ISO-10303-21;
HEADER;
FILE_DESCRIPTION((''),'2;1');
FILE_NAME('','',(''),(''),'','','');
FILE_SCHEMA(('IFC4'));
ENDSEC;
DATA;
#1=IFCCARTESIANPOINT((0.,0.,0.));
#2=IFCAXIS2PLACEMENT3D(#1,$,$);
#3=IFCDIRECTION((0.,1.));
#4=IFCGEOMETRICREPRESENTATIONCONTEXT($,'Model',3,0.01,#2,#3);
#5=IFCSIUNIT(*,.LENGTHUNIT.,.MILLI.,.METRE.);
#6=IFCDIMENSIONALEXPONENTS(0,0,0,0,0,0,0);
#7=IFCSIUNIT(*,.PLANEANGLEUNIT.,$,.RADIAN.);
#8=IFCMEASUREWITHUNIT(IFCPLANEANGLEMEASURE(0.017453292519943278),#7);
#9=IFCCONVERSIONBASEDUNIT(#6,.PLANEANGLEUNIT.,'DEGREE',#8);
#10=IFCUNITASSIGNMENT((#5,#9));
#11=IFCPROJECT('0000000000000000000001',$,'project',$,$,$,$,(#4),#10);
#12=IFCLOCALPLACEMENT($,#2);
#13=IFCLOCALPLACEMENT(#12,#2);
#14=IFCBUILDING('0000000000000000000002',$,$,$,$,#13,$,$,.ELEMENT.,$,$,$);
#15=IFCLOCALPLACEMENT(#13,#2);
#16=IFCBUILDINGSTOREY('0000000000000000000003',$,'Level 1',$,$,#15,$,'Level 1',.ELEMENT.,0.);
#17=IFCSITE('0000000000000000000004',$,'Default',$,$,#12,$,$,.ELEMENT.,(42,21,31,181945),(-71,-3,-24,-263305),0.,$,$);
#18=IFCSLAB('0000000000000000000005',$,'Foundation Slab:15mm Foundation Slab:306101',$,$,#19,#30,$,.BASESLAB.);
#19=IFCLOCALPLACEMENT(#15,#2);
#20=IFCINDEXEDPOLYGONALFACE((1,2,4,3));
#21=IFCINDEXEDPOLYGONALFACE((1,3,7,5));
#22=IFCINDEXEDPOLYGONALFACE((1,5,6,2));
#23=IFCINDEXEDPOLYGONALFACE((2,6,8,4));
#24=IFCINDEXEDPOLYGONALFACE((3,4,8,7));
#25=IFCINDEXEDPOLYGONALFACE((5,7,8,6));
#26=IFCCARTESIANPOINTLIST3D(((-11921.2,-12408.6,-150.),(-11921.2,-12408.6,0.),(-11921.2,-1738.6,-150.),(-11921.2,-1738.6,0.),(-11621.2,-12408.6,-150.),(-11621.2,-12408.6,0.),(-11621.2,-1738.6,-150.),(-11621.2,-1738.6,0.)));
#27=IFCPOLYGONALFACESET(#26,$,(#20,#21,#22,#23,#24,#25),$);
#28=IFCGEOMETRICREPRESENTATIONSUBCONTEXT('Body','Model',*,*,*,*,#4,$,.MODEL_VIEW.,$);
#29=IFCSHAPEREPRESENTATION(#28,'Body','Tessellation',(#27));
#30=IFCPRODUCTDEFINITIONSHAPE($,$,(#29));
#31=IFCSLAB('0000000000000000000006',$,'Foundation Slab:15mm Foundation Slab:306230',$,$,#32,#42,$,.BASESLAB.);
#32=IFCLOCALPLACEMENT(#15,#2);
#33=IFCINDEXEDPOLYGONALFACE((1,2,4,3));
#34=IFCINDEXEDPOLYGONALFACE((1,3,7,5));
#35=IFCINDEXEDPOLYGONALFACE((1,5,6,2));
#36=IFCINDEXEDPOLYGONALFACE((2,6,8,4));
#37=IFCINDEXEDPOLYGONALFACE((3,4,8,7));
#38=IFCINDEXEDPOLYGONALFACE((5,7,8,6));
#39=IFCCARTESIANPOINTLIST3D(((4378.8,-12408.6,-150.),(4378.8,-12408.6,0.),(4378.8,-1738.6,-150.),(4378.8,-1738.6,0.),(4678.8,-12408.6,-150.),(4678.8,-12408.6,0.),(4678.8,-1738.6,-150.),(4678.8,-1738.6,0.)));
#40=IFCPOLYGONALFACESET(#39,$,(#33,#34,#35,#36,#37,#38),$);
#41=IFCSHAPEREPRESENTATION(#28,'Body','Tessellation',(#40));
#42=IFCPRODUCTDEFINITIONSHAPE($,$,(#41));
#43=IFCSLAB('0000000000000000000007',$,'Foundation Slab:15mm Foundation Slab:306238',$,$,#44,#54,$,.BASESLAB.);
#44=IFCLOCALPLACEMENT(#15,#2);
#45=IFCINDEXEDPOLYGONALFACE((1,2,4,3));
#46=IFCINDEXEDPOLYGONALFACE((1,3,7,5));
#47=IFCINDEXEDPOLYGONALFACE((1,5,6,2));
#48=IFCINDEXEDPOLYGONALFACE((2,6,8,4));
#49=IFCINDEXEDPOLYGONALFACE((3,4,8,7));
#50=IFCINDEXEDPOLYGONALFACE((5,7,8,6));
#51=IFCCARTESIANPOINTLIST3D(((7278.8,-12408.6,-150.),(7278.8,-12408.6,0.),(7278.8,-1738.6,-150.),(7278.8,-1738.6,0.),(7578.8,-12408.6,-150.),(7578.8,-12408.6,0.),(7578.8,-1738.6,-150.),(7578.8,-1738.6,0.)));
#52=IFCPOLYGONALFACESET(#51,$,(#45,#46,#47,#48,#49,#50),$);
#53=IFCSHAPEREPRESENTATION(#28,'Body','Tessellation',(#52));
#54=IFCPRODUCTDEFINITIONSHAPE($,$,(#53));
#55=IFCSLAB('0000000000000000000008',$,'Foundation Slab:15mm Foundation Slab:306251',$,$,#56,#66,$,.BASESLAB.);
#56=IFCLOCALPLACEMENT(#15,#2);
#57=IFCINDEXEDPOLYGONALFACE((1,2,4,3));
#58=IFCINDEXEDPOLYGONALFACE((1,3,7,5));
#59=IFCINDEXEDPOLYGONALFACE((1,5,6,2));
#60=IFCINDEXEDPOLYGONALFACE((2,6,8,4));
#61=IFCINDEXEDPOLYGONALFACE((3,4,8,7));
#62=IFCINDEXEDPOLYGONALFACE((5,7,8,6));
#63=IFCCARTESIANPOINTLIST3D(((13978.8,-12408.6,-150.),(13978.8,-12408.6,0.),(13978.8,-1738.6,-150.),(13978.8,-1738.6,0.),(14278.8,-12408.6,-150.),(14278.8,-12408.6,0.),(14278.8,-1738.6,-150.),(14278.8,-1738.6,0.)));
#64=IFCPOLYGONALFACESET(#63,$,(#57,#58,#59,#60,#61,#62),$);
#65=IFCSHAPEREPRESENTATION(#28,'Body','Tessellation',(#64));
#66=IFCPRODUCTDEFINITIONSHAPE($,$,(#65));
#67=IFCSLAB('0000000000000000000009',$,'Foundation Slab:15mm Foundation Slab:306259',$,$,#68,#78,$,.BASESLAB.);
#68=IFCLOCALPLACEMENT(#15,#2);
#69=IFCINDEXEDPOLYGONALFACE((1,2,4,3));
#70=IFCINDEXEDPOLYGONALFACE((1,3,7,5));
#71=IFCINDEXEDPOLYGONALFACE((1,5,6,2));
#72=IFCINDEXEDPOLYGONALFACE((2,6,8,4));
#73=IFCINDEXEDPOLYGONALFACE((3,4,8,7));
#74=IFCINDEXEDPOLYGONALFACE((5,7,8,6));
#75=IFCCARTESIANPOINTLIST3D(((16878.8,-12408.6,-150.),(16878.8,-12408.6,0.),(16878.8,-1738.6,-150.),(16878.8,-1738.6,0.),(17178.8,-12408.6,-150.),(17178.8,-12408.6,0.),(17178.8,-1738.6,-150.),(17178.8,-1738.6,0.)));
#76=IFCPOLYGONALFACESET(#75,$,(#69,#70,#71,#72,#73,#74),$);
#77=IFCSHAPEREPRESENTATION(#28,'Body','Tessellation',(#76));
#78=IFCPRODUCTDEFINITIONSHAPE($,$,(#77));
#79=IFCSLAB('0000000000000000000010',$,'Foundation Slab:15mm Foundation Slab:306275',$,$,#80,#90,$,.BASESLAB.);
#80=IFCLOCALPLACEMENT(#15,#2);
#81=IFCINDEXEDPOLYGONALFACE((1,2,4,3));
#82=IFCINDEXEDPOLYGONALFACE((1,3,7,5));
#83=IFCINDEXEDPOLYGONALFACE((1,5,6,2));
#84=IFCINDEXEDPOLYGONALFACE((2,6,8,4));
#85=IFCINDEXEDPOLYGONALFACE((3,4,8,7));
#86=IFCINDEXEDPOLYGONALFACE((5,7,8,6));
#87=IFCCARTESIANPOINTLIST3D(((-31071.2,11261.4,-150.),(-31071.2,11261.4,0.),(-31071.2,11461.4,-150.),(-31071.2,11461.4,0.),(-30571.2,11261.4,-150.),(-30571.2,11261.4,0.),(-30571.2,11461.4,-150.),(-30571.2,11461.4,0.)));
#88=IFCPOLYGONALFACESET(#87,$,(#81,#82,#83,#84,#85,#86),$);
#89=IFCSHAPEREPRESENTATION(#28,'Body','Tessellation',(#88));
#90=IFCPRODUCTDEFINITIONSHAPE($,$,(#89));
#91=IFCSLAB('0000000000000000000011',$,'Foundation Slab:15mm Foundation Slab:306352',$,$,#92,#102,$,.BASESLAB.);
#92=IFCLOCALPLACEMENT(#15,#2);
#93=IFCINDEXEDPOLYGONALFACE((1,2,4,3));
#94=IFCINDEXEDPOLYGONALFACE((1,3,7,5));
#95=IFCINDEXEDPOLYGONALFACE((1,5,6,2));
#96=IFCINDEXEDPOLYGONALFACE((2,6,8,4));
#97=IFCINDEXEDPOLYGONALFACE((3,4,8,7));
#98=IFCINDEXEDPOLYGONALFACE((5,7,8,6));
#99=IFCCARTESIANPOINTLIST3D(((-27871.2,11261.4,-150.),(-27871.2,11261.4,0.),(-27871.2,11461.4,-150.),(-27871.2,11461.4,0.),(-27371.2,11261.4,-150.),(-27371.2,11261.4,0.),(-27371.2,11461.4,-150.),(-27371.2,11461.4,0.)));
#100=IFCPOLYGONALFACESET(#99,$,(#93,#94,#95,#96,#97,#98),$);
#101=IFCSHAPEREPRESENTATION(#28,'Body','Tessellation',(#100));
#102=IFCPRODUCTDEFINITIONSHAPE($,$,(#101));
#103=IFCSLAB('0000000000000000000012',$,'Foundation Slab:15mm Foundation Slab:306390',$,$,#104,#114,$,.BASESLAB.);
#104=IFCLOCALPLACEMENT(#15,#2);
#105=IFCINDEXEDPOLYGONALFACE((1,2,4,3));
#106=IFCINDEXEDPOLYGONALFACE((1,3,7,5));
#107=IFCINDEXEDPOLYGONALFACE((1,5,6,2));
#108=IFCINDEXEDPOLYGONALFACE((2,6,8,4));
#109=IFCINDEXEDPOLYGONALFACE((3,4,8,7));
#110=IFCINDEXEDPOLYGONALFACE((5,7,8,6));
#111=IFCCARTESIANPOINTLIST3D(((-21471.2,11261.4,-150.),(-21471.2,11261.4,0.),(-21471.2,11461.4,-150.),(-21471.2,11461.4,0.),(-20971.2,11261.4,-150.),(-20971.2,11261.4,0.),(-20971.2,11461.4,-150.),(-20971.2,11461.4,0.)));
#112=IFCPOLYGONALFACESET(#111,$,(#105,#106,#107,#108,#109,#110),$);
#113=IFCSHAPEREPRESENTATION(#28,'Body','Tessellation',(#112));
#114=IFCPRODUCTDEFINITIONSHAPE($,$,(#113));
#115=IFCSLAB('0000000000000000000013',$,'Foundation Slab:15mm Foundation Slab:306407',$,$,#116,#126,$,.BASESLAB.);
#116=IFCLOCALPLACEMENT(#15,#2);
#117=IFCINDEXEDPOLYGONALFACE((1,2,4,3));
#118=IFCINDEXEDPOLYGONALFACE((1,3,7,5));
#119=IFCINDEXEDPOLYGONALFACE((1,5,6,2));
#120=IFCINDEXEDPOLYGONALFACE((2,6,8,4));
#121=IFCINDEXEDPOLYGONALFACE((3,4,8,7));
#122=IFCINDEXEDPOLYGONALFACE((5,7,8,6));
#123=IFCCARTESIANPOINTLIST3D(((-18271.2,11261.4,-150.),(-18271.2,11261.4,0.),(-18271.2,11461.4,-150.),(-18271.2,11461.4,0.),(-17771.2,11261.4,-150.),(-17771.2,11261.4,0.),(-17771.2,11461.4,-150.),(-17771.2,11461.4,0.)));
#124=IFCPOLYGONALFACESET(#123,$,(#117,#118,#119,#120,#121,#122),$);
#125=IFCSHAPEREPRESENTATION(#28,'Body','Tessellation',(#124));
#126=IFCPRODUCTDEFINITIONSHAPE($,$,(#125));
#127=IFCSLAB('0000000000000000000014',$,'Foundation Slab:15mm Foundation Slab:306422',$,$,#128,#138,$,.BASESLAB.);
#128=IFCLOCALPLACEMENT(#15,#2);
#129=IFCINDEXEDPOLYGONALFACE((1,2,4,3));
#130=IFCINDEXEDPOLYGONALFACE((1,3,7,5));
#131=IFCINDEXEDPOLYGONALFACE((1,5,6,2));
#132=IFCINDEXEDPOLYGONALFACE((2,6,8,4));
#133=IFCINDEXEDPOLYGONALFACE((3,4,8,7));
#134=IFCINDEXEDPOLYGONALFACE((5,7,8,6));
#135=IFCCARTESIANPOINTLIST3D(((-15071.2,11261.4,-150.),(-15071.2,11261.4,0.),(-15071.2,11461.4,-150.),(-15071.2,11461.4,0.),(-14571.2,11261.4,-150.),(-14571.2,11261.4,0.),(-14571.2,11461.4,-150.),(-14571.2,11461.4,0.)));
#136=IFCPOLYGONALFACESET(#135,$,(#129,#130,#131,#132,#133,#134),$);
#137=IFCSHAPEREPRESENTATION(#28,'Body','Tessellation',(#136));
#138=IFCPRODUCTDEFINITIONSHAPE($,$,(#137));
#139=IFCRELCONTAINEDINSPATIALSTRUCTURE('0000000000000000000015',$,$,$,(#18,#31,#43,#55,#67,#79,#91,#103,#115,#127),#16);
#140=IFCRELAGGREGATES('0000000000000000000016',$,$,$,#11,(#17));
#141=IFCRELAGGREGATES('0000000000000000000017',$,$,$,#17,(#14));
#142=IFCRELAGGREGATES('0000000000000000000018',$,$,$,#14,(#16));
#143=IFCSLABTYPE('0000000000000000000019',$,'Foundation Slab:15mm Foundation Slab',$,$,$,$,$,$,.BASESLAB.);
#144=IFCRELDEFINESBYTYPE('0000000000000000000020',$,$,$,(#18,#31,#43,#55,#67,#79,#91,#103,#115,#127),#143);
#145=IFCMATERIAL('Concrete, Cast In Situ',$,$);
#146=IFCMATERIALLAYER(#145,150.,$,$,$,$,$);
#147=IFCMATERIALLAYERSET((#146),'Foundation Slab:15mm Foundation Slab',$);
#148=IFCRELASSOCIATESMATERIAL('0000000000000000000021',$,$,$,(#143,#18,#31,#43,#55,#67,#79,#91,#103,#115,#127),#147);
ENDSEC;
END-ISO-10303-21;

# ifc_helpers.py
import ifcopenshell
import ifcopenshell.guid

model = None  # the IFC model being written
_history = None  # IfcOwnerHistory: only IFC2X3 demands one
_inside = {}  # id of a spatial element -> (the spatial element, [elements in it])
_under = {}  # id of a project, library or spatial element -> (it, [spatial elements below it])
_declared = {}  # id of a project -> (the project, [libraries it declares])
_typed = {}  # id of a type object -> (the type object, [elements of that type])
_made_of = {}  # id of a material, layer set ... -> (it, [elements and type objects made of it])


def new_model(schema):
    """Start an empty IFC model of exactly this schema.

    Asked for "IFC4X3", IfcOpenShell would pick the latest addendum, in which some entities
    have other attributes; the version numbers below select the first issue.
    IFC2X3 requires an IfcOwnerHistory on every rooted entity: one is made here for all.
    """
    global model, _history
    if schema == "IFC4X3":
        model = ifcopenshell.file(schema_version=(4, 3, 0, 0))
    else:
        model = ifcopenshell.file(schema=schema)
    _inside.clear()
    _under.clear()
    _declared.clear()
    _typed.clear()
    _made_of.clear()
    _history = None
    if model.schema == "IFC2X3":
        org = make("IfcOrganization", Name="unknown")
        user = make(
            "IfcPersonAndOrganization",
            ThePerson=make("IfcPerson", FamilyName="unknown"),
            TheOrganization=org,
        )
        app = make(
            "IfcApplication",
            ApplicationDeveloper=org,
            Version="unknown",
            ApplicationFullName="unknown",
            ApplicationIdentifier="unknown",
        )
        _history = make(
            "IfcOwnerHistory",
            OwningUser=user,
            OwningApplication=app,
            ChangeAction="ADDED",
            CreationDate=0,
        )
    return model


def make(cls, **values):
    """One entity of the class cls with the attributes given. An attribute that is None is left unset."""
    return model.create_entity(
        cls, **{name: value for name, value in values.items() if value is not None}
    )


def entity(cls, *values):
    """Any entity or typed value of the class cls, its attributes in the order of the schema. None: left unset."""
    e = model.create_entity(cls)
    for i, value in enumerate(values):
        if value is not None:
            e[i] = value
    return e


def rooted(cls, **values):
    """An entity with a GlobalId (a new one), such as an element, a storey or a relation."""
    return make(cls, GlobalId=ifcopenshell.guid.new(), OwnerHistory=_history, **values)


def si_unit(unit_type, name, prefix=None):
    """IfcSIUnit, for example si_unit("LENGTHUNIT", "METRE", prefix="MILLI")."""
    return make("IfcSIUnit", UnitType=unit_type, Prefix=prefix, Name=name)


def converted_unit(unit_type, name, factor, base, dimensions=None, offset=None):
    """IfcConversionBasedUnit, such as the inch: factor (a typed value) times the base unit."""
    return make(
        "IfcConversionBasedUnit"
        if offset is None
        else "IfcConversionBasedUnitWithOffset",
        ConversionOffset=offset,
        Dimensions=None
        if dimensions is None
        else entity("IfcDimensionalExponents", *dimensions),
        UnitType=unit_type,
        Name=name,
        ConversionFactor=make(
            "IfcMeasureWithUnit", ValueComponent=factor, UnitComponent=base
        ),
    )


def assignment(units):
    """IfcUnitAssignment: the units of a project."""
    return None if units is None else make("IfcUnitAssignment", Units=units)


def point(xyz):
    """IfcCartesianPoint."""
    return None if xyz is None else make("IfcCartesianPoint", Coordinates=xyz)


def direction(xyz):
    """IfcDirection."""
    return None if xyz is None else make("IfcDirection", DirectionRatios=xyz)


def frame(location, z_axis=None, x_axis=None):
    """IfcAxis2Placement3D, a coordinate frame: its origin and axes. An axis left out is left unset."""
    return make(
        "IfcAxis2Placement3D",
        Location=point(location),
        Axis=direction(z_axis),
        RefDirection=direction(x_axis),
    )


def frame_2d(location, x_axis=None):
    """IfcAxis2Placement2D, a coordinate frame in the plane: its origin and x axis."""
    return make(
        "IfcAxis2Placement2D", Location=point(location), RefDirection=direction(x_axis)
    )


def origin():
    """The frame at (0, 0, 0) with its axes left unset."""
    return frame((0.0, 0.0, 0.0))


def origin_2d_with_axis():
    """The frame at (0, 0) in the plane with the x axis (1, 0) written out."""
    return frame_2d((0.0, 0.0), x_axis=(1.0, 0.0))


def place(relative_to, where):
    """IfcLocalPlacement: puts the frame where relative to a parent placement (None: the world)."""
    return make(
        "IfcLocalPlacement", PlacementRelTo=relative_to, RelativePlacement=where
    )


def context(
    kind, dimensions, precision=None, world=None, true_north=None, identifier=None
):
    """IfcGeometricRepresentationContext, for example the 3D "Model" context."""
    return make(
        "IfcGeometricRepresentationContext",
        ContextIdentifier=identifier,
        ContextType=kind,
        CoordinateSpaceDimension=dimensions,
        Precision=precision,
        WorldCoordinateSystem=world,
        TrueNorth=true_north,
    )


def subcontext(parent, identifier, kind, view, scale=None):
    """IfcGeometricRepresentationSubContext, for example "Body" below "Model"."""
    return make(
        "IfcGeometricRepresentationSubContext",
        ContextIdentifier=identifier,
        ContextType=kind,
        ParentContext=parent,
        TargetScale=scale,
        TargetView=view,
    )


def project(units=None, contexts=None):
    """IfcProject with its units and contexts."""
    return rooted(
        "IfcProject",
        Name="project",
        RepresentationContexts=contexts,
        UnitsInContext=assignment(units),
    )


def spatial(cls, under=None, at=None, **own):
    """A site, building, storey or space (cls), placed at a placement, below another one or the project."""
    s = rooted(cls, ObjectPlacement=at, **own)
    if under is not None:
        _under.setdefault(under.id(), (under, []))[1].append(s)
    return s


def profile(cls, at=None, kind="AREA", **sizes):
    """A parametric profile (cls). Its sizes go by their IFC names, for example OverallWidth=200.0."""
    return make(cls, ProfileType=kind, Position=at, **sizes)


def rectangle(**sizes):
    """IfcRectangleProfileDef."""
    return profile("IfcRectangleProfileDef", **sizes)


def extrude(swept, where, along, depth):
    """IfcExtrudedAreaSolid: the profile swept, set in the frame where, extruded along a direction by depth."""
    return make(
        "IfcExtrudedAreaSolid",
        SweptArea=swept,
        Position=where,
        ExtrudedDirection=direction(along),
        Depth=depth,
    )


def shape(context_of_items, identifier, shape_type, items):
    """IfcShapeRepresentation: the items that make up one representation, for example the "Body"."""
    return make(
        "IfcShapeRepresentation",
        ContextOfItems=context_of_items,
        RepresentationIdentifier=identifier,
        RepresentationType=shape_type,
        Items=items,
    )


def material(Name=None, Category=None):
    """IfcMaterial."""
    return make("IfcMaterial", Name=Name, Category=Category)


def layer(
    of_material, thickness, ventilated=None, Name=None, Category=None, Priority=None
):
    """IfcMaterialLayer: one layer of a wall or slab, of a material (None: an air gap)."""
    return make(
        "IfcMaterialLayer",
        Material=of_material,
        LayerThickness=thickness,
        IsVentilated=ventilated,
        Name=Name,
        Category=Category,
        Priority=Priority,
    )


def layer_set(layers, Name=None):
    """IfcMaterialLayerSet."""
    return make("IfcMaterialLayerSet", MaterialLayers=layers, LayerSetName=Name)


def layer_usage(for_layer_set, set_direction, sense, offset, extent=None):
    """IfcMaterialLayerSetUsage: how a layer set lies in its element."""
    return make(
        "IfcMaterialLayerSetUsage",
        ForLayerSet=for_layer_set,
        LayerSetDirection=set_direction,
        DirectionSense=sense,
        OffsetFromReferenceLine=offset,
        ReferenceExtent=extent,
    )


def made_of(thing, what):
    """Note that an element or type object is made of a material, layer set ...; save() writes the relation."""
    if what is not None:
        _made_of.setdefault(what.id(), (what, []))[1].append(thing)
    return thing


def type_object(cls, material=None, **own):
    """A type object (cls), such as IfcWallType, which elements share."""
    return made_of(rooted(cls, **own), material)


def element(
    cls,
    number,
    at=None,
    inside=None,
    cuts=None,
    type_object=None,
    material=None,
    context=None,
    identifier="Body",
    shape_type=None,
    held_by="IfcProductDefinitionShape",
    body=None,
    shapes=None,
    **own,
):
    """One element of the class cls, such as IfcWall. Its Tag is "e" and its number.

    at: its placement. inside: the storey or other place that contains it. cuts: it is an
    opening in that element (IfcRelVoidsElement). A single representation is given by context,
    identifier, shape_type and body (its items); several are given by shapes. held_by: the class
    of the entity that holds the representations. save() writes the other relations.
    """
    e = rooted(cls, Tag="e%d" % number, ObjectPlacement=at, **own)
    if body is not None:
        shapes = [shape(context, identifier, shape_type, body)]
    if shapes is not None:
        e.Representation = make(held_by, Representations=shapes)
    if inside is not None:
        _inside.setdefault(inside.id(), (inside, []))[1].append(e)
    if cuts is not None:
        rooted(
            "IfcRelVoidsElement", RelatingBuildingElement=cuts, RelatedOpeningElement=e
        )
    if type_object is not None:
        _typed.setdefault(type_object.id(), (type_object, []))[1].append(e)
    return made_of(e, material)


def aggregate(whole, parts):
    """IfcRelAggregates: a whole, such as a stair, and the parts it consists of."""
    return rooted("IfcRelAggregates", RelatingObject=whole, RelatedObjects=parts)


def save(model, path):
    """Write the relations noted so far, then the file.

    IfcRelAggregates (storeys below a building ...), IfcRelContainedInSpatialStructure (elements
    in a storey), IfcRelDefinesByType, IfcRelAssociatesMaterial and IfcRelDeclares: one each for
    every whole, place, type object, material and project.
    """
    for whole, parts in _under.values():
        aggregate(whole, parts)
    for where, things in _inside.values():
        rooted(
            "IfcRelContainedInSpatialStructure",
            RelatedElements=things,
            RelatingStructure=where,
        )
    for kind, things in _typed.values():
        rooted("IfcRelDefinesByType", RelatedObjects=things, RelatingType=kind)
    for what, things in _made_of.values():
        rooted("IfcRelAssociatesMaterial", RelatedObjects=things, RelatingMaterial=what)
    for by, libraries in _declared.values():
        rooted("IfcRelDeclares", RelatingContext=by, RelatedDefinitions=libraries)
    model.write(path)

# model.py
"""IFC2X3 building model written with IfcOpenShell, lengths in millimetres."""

from ifc_helpers import new_model, entity, si_unit, converted_unit, direction, frame, frame_2d, origin, origin_2d_with_axis, place, context, subcontext, project, spatial, rectangle, extrude, material, layer, layer_set, layer_usage, type_object, element, save


model = new_model("IFC2X3")

# Units and contexts
model_context = context("Model", 3, precision=0.01, world=origin(), true_north=direction((0.0, 1.0)))
body_context = subcontext(model_context, "Body", "Model", "MODEL_VIEW")
ifc_project = project(units=[si_unit("LENGTHUNIT", "METRE", prefix="MILLI"), converted_unit("PLANEANGLEUNIT", "DEGREE", entity("IfcPlaneAngleMeasure", 0.017453292519943278), si_unit("PLANEANGLEUNIT", "RADIAN"), dimensions=[0, 0, 0, 0, 0, 0, 0])], contexts=[model_context])

# Site, building, storey
site_placement = place(None, origin())
site = spatial("IfcSite", under=ifc_project, at=site_placement, Name="Default", CompositionType="ELEMENT", RefLatitude=(42, 21, 31, 181945), RefLongitude=(-71, -3, -24, -263305), RefElevation=0.0)
building_placement = place(site_placement, origin())
building = spatial("IfcBuilding", under=site, at=building_placement, CompositionType="ELEMENT")
storey_placement = place(building_placement, origin())
storey = spatial("IfcBuildingStorey", under=building, at=storey_placement, Name="Level 1", LongName="Level 1", CompositionType="ELEMENT", Elevation=0.0)

# Slabs
ifc_material = material(Name="Concrete, Cast In Situ")
ifc_layer = layer(ifc_material, 150.0)
ifc_layer_set = layer_set([ifc_layer], Name="Foundation Slab:15mm Foundation Slab")
slab_type = type_object("IfcSlabType", Name="Foundation Slab:15mm Foundation Slab", PredefinedType="BASESLAB", material=ifc_layer_set)
ifc_layer_usage_1 = layer_usage(ifc_layer_set, "AXIS3", "POSITIVE", 0.0)
slab_1_placement = place(storey_placement, origin())
element("IfcSlab", 1, at=slab_1_placement, inside=storey, type_object=slab_type, material=ifc_layer_usage_1, Name="Foundation Slab:15mm Foundation Slab:306101", PredefinedType="BASESLAB", context=body_context, shape_type="SweptSolid", body=[
    extrude(rectangle(XDim=10670.0, YDim=300.0, at=origin_2d_with_axis()), frame((-11771.2, -7073.6, 0.0), z_axis=(0.0, 0.0, -1.0), x_axis=(0.0, 1.0, 0.0)), (0.0, 0.0, 1.0), 150.0),
])
ifc_layer_usage_2 = layer_usage(ifc_layer_set, "AXIS3", "POSITIVE", 0.0)
slab_2_placement = place(storey_placement, origin())
element("IfcSlab", 2, at=slab_2_placement, inside=storey, type_object=slab_type, material=ifc_layer_usage_2, Name="Foundation Slab:15mm Foundation Slab:306230", PredefinedType="BASESLAB", context=body_context, shape_type="SweptSolid", body=[
    extrude(rectangle(XDim=10670.0, YDim=300.0, at=origin_2d_with_axis()), frame((4528.8, -7073.6, 0.0), z_axis=(0.0, 0.0, -1.0), x_axis=(0.0, 1.0, 0.0)), (0.0, 0.0, 1.0), 150.0),
])
ifc_layer_usage_3 = layer_usage(ifc_layer_set, "AXIS3", "POSITIVE", 0.0)
slab_3_placement = place(storey_placement, origin())
element("IfcSlab", 3, at=slab_3_placement, inside=storey, type_object=slab_type, material=ifc_layer_usage_3, Name="Foundation Slab:15mm Foundation Slab:306238", PredefinedType="BASESLAB", context=body_context, shape_type="SweptSolid", body=[
    extrude(rectangle(XDim=10670.0, YDim=300.0, at=origin_2d_with_axis()), frame((7428.8, -7073.6, 0.0), z_axis=(0.0, 0.0, -1.0), x_axis=(0.0, 1.0, 0.0)), (0.0, 0.0, 1.0), 150.0),
])
ifc_layer_usage_4 = layer_usage(ifc_layer_set, "AXIS3", "POSITIVE", 0.0)
slab_4_placement = place(storey_placement, origin())
element("IfcSlab", 4, at=slab_4_placement, inside=storey, type_object=slab_type, material=ifc_layer_usage_4, Name="Foundation Slab:15mm Foundation Slab:306251", PredefinedType="BASESLAB", context=body_context, shape_type="SweptSolid", body=[
    extrude(rectangle(XDim=10670.0, YDim=300.0, at=origin_2d_with_axis()), frame((14128.8, -7073.6, 0.0), z_axis=(0.0, 0.0, -1.0), x_axis=(0.0, 1.0, 0.0)), (0.0, 0.0, 1.0), 150.0),
])
ifc_layer_usage_5 = layer_usage(ifc_layer_set, "AXIS3", "POSITIVE", 0.0)
slab_5_placement = place(storey_placement, origin())
element("IfcSlab", 5, at=slab_5_placement, inside=storey, type_object=slab_type, material=ifc_layer_usage_5, Name="Foundation Slab:15mm Foundation Slab:306259", PredefinedType="BASESLAB", context=body_context, shape_type="SweptSolid", body=[
    extrude(rectangle(XDim=10670.0, YDim=300.0, at=origin_2d_with_axis()), frame((17028.8, -7073.6, 0.0), z_axis=(0.0, 0.0, -1.0), x_axis=(0.0, 1.0, 0.0)), (0.0, 0.0, 1.0), 150.0),
])
ifc_layer_usage_6 = layer_usage(ifc_layer_set, "AXIS3", "POSITIVE", 0.0)
slab_6_placement = place(storey_placement, origin())
element("IfcSlab", 6, at=slab_6_placement, inside=storey, type_object=slab_type, material=ifc_layer_usage_6, Name="Foundation Slab:15mm Foundation Slab:306275", PredefinedType="BASESLAB", context=body_context, shape_type="SweptSolid", body=[
    extrude(rectangle(XDim=200.0, YDim=500.0, at=frame_2d((0.0, 0.0), x_axis=(1.0, 0.0))), frame((-30821.2, 11361.4, 0.0), z_axis=(0.0, 0.0, -1.0), x_axis=(0.0, 1.0, 0.0)), (0.0, 0.0, 1.0), 150.0),
])
ifc_layer_usage_7 = layer_usage(ifc_layer_set, "AXIS3", "POSITIVE", 0.0)
slab_7_placement = place(storey_placement, origin())
element("IfcSlab", 7, at=slab_7_placement, inside=storey, type_object=slab_type, material=ifc_layer_usage_7, Name="Foundation Slab:15mm Foundation Slab:306352", PredefinedType="BASESLAB", context=body_context, shape_type="SweptSolid", body=[
    extrude(rectangle(XDim=200.0, YDim=500.0, at=frame_2d((0.0, 0.0), x_axis=(1.0, 0.0))), frame((-27621.2, 11361.4, 0.0), z_axis=(0.0, 0.0, -1.0), x_axis=(0.0, 1.0, 0.0)), (0.0, 0.0, 1.0), 150.0),
])
ifc_layer_usage_8 = layer_usage(ifc_layer_set, "AXIS3", "POSITIVE", 0.0)
slab_8_placement = place(storey_placement, origin())
element("IfcSlab", 8, at=slab_8_placement, inside=storey, type_object=slab_type, material=ifc_layer_usage_8, Name="Foundation Slab:15mm Foundation Slab:306390", PredefinedType="BASESLAB", context=body_context, shape_type="SweptSolid", body=[
    extrude(rectangle(XDim=200.0, YDim=500.0, at=frame_2d((0.0, 0.0), x_axis=(1.0, 0.0))), frame((-21221.2, 11361.4, 0.0), z_axis=(0.0, 0.0, -1.0), x_axis=(0.0, 1.0, 0.0)), (0.0, 0.0, 1.0), 150.0),
])
ifc_layer_usage_9 = layer_usage(ifc_layer_set, "AXIS3", "POSITIVE", 0.0)
slab_9_placement = place(storey_placement, origin())
element("IfcSlab", 9, at=slab_9_placement, inside=storey, type_object=slab_type, material=ifc_layer_usage_9, Name="Foundation Slab:15mm Foundation Slab:306407", PredefinedType="BASESLAB", context=body_context, shape_type="SweptSolid", body=[
    extrude(rectangle(XDim=200.0, YDim=500.0, at=frame_2d((0.0, 0.0), x_axis=(1.0, 0.0))), frame((-18021.2, 11361.4, 0.0), z_axis=(0.0, 0.0, -1.0), x_axis=(0.0, 1.0, 0.0)), (0.0, 0.0, 1.0), 150.0),
])
ifc_layer_usage_10 = layer_usage(ifc_layer_set, "AXIS3", "POSITIVE", 0.0)
slab_10_placement = place(storey_placement, origin())
element("IfcSlab", 10, at=slab_10_placement, inside=storey, type_object=slab_type, material=ifc_layer_usage_10, Name="Foundation Slab:15mm Foundation Slab:306422", PredefinedType="BASESLAB", context=body_context, shape_type="SweptSolid", body=[
    extrude(rectangle(XDim=200.0, YDim=500.0, at=frame_2d((0.0, 0.0), x_axis=(1.0, 0.0))), frame((-14821.2, 11361.4, 0.0), z_axis=(0.0, 0.0, -1.0), x_axis=(0.0, 1.0, 0.0)), (0.0, 0.0, 1.0), 150.0),
])

save(model, "model.ifc")
